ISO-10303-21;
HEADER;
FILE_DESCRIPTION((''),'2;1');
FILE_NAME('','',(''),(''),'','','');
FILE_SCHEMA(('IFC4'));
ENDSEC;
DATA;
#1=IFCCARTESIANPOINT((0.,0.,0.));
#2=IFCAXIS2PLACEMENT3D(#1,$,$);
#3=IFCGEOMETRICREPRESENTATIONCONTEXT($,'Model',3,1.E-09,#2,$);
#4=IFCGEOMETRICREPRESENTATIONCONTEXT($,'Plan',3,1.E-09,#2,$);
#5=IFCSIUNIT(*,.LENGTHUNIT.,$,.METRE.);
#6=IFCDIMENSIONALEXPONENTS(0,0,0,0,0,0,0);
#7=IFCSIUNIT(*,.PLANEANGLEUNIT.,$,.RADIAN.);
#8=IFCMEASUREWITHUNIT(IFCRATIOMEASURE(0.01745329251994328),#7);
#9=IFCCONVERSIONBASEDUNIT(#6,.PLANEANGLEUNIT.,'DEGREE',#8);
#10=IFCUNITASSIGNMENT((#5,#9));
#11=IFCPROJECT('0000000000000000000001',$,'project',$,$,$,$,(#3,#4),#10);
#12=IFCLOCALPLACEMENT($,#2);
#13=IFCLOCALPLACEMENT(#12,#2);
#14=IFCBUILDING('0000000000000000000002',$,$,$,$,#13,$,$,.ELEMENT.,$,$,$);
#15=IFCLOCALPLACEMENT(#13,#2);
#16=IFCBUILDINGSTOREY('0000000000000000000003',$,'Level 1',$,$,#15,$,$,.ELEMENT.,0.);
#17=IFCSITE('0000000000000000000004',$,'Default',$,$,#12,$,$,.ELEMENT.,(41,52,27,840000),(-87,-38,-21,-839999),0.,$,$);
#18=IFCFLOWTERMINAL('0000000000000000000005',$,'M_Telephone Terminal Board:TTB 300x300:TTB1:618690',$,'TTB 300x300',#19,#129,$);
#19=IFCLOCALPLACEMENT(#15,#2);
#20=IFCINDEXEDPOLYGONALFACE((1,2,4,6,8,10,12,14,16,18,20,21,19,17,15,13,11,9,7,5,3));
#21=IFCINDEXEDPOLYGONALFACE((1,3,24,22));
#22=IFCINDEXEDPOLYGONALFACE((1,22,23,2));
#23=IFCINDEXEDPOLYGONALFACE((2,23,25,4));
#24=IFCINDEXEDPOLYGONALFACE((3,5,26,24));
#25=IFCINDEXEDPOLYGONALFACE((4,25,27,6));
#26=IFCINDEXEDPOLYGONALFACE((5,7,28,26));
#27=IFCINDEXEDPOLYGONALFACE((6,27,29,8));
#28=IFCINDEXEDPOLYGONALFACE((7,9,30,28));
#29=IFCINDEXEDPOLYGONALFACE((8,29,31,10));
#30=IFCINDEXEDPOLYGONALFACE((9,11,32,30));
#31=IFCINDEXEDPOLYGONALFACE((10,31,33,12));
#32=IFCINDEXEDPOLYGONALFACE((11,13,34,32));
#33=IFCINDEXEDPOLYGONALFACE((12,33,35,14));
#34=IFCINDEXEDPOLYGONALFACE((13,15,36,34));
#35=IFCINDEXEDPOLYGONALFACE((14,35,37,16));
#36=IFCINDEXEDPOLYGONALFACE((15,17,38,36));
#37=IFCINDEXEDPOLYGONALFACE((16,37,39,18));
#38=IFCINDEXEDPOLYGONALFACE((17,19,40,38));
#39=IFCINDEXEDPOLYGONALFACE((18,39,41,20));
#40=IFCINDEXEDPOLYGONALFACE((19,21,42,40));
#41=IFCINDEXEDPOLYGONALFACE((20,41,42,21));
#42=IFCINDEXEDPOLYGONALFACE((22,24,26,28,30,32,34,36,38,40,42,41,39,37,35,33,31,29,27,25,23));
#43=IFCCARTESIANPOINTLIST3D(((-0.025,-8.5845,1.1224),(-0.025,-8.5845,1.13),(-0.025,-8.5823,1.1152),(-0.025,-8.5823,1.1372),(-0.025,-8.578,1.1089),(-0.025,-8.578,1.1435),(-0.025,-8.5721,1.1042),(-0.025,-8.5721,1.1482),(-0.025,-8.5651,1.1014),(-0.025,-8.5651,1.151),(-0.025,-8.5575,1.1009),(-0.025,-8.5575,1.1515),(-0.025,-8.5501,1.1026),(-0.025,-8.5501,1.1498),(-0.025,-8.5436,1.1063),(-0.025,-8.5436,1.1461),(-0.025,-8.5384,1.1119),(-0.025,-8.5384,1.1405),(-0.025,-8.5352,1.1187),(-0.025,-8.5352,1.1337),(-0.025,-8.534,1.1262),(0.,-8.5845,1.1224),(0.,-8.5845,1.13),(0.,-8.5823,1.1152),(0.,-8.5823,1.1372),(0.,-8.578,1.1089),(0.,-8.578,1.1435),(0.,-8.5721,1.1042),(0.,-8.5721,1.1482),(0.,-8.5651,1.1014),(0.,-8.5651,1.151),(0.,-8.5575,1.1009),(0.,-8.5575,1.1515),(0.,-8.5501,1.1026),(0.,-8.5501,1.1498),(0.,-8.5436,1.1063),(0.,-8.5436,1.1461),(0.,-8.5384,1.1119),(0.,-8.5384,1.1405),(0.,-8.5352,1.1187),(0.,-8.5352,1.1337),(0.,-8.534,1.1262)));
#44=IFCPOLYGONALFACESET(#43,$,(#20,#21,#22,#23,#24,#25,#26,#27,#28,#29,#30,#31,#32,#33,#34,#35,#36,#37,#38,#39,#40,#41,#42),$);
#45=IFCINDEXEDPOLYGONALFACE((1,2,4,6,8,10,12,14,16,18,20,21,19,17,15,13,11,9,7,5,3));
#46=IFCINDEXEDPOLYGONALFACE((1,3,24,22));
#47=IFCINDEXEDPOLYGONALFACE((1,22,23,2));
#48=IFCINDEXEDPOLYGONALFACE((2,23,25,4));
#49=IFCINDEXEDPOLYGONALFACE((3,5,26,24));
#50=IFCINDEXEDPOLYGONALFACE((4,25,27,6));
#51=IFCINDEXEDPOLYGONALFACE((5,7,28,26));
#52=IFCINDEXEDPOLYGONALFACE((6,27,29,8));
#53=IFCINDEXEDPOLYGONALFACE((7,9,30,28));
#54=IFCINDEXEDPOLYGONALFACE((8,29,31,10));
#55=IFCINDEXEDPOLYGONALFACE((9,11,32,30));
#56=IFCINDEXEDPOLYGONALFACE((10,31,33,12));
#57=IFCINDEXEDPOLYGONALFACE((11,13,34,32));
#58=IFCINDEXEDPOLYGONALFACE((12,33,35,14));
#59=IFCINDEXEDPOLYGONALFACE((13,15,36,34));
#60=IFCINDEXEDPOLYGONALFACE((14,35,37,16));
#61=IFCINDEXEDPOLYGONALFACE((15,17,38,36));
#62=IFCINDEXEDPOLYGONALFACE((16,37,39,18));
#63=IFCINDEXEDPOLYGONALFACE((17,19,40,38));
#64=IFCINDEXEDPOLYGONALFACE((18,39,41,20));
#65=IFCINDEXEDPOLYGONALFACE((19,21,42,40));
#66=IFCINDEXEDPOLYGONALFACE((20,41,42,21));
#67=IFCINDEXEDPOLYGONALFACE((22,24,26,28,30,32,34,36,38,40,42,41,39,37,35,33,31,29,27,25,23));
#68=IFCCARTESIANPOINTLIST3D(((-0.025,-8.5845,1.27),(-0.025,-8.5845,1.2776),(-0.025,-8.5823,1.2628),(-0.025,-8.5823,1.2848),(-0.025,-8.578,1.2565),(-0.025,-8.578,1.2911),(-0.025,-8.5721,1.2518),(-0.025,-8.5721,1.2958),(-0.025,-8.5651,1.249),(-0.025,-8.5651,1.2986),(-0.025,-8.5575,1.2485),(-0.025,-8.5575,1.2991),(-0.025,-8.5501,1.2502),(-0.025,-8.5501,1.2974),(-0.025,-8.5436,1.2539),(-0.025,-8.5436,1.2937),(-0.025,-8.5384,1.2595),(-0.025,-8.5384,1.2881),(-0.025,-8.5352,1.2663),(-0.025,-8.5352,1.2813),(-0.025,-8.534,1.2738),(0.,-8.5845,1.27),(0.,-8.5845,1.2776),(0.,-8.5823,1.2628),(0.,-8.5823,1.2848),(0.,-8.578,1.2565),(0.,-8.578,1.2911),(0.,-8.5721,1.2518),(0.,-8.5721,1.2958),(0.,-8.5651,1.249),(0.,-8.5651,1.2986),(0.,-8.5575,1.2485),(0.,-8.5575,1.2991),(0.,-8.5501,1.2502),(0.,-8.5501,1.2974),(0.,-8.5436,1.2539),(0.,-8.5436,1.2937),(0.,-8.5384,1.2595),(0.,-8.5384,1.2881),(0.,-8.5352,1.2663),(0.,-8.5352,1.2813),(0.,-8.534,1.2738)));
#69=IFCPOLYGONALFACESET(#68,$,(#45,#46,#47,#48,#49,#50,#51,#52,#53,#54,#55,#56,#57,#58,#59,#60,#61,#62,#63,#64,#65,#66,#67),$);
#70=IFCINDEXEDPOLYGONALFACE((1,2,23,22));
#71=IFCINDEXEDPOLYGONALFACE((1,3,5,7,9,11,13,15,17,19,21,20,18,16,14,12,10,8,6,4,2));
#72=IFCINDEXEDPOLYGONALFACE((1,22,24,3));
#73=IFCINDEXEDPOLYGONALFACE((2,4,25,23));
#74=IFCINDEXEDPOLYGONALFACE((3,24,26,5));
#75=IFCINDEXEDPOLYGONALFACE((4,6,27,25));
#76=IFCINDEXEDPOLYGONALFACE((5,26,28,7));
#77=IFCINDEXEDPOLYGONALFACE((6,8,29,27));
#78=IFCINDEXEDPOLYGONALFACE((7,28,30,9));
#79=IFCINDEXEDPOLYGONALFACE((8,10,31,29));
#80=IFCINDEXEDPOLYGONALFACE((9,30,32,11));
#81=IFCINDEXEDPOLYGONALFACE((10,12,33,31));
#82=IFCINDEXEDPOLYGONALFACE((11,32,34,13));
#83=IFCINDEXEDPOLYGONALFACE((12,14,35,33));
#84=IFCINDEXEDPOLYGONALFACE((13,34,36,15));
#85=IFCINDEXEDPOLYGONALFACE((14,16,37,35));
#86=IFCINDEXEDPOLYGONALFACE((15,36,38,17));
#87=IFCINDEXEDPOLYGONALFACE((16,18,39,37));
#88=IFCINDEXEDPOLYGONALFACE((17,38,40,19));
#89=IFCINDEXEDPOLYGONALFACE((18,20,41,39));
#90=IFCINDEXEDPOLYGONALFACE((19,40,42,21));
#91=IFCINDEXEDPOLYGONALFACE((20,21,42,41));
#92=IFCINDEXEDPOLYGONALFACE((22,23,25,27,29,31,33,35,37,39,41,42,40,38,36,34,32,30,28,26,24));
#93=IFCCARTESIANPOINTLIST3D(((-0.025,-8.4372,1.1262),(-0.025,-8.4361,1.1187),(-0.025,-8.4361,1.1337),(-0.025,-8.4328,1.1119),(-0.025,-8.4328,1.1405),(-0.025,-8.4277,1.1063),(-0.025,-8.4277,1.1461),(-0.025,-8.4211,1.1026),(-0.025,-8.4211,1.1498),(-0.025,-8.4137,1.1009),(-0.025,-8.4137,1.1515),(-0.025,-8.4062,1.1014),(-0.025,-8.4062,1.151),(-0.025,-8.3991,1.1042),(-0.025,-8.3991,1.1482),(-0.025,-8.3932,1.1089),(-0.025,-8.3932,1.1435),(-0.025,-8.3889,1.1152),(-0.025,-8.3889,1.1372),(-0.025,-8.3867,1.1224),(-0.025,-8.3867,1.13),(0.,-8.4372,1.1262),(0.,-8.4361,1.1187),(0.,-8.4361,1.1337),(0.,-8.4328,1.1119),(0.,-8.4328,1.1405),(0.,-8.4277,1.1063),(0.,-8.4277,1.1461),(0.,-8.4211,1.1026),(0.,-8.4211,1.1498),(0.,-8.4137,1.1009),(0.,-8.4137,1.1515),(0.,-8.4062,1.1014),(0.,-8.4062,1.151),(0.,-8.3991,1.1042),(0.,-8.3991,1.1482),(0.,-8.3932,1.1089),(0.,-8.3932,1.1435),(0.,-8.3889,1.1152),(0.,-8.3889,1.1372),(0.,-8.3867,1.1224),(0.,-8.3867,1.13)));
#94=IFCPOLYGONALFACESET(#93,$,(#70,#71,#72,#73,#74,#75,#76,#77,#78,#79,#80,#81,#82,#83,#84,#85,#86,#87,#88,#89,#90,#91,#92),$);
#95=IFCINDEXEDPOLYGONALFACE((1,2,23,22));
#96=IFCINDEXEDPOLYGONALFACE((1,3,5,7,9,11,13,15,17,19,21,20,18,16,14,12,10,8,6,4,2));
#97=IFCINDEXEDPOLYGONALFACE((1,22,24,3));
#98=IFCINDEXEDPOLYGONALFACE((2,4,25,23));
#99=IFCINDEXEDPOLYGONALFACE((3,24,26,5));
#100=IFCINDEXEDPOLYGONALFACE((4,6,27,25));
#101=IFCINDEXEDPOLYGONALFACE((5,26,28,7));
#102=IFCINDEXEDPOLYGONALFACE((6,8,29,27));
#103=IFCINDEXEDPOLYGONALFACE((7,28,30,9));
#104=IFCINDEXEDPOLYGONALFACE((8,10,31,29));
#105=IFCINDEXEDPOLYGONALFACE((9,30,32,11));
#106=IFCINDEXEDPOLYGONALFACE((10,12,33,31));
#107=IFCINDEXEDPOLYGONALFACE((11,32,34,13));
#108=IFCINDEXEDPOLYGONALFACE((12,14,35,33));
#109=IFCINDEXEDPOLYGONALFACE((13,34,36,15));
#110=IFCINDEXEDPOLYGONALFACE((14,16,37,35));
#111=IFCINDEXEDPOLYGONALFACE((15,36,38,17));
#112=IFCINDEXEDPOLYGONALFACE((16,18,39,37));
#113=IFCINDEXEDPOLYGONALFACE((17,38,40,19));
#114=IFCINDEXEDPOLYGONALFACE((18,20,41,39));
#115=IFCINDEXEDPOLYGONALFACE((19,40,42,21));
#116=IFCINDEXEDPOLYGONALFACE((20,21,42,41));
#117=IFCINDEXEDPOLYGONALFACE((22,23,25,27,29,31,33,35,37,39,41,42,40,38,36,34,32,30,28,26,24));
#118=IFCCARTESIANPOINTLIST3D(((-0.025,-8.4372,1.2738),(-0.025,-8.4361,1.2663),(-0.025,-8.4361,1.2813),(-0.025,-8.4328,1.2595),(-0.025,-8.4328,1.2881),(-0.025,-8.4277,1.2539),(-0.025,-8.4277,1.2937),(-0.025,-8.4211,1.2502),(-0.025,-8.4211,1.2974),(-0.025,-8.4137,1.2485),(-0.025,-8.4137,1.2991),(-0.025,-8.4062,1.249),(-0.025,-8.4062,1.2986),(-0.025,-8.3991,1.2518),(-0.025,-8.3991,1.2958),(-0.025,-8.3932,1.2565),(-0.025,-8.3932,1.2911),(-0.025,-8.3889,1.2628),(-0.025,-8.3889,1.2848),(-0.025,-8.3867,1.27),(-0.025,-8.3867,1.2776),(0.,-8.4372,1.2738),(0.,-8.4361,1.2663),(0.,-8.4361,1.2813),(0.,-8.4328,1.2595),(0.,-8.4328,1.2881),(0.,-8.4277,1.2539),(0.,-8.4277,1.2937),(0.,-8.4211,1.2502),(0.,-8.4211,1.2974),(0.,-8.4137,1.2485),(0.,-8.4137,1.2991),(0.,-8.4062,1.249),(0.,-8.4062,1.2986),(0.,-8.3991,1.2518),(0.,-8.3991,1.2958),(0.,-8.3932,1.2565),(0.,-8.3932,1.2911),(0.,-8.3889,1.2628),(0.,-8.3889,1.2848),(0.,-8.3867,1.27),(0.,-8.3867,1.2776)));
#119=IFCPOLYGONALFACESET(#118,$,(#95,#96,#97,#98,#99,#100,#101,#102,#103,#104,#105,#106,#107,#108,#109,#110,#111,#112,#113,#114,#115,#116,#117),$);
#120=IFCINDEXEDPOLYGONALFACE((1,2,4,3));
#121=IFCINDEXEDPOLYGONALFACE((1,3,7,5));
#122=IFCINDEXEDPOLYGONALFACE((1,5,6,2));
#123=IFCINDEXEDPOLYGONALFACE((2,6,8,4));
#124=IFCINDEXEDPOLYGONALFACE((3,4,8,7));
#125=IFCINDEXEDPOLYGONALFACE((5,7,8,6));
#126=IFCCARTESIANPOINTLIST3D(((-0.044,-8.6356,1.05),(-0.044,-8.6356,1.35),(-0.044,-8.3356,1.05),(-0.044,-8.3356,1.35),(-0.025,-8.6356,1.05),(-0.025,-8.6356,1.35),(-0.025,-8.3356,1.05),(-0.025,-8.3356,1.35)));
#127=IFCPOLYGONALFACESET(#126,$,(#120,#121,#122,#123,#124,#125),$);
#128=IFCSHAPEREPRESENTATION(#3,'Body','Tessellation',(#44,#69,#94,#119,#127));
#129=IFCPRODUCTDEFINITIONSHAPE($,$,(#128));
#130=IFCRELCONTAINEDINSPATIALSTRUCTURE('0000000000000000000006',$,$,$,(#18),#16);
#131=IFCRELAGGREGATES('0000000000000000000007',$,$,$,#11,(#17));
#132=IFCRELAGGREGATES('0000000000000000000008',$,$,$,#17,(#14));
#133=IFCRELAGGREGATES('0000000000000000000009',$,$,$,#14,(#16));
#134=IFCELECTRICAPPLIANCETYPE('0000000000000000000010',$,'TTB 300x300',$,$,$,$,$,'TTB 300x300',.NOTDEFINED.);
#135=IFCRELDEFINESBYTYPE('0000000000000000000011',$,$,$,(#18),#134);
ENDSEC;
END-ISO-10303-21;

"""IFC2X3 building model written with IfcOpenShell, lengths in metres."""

from ifc_helpers import new_model, entity, si_unit, converted_unit, frame, origin, origin_2d_with_axis, place, context, project, spatial, rectangle, circle, extrude, source, transform, mapped, type_object, type_shapes, element, save


model = new_model("IFC2X3")

# Units and contexts
model_context = context("Model", 3, precision=1e-09, world=origin())
plan_context = context("Plan", 3, precision=1e-09, world=origin())
ifc_project = project(units=[si_unit("LENGTHUNIT", "METRE"), converted_unit("PLANEANGLEUNIT", "DEGREE", entity("IfcRatioMeasure", 0.01745329251994328), si_unit("PLANEANGLEUNIT", "RADIAN"), dimensions=[0, 0, 0, 0, 0, 0, 0])], contexts=[model_context, plan_context])

# Site, building, storey
site_placement = place(None, origin())
site = spatial("IfcSite", under=ifc_project, at=site_placement, Name="Default", CompositionType="ELEMENT", RefLatitude=(41, 52, 27, 840000), RefLongitude=(-87, -38, -21, -839999), RefElevation=0.0)
building_placement = place(site_placement, origin())
building = spatial("IfcBuilding", under=site, at=building_placement, CompositionType="ELEMENT")
storey_placement = place(building_placement, origin())
storey = spatial("IfcBuildingStorey", under=building, at=storey_placement, Name="Level 1", CompositionType="ELEMENT", Elevation=0.0)

# Flow terminal
electric_appliance_type_1 = type_object("IfcElectricApplianceType", Name="TTB 300x300", ElementType="TTB 300x300", PredefinedType="NOTDEFINED")
shared_shape_1 = source(origin(), model_context, "Body", "SweptSolid", [
    extrude(circle(Radius=0.0254, at=origin_2d_with_axis()), frame((0.0738, -0.0738, 0.0), z_axis=(0.0, 0.0, 1.0), x_axis=(-1.0, 0.0, 0.0)), (0.0, 0.0, 1.0), 0.025),
    extrude(circle(Radius=0.0254, at=origin_2d_with_axis()), frame((0.0738, 0.0738, 0.0), z_axis=(0.0, 0.0, 1.0), x_axis=(-1.0, 0.0, 0.0)), (0.0, 0.0, 1.0), 0.025),
    extrude(circle(Radius=0.0254, at=origin_2d_with_axis()), frame((-0.0738, -0.0738, 0.0)), (0.0, 0.0, 1.0), 0.025),
    extrude(circle(Radius=0.0254, at=origin_2d_with_axis()), frame((-0.0738, 0.0738, 0.0)), (0.0, 0.0, 1.0), 0.025),
    extrude(rectangle(XDim=0.3, YDim=0.3, at=origin_2d_with_axis()), frame((0.0, 0.0, 0.025), z_axis=(0.0, 0.0, 1.0), x_axis=(-1.0, 0.0, 0.0)), (0.0, 0.0, 1.0), 0.019),
])
type_shapes(electric_appliance_type_1, [shared_shape_1])
flow_terminal_1_placement = place(storey_placement, frame((0.0, -8.4856, 1.2), z_axis=(-1.0, 0.0, 0.0), x_axis=(0.0, -1.0, 0.0)))
element("IfcFlowTerminal", 1, at=flow_terminal_1_placement, inside=storey, type_object=electric_appliance_type_1, Name="M_Telephone Terminal Board:TTB 300x300:TTB1:618690", ObjectType="TTB 300x300", context=model_context, shape_type="MappedRepresentation", body=[
    mapped(shared_shape_1, transform((0.0, 0.0, 0.0), scale=1.0)),
])

save(model, "model.ifc")
